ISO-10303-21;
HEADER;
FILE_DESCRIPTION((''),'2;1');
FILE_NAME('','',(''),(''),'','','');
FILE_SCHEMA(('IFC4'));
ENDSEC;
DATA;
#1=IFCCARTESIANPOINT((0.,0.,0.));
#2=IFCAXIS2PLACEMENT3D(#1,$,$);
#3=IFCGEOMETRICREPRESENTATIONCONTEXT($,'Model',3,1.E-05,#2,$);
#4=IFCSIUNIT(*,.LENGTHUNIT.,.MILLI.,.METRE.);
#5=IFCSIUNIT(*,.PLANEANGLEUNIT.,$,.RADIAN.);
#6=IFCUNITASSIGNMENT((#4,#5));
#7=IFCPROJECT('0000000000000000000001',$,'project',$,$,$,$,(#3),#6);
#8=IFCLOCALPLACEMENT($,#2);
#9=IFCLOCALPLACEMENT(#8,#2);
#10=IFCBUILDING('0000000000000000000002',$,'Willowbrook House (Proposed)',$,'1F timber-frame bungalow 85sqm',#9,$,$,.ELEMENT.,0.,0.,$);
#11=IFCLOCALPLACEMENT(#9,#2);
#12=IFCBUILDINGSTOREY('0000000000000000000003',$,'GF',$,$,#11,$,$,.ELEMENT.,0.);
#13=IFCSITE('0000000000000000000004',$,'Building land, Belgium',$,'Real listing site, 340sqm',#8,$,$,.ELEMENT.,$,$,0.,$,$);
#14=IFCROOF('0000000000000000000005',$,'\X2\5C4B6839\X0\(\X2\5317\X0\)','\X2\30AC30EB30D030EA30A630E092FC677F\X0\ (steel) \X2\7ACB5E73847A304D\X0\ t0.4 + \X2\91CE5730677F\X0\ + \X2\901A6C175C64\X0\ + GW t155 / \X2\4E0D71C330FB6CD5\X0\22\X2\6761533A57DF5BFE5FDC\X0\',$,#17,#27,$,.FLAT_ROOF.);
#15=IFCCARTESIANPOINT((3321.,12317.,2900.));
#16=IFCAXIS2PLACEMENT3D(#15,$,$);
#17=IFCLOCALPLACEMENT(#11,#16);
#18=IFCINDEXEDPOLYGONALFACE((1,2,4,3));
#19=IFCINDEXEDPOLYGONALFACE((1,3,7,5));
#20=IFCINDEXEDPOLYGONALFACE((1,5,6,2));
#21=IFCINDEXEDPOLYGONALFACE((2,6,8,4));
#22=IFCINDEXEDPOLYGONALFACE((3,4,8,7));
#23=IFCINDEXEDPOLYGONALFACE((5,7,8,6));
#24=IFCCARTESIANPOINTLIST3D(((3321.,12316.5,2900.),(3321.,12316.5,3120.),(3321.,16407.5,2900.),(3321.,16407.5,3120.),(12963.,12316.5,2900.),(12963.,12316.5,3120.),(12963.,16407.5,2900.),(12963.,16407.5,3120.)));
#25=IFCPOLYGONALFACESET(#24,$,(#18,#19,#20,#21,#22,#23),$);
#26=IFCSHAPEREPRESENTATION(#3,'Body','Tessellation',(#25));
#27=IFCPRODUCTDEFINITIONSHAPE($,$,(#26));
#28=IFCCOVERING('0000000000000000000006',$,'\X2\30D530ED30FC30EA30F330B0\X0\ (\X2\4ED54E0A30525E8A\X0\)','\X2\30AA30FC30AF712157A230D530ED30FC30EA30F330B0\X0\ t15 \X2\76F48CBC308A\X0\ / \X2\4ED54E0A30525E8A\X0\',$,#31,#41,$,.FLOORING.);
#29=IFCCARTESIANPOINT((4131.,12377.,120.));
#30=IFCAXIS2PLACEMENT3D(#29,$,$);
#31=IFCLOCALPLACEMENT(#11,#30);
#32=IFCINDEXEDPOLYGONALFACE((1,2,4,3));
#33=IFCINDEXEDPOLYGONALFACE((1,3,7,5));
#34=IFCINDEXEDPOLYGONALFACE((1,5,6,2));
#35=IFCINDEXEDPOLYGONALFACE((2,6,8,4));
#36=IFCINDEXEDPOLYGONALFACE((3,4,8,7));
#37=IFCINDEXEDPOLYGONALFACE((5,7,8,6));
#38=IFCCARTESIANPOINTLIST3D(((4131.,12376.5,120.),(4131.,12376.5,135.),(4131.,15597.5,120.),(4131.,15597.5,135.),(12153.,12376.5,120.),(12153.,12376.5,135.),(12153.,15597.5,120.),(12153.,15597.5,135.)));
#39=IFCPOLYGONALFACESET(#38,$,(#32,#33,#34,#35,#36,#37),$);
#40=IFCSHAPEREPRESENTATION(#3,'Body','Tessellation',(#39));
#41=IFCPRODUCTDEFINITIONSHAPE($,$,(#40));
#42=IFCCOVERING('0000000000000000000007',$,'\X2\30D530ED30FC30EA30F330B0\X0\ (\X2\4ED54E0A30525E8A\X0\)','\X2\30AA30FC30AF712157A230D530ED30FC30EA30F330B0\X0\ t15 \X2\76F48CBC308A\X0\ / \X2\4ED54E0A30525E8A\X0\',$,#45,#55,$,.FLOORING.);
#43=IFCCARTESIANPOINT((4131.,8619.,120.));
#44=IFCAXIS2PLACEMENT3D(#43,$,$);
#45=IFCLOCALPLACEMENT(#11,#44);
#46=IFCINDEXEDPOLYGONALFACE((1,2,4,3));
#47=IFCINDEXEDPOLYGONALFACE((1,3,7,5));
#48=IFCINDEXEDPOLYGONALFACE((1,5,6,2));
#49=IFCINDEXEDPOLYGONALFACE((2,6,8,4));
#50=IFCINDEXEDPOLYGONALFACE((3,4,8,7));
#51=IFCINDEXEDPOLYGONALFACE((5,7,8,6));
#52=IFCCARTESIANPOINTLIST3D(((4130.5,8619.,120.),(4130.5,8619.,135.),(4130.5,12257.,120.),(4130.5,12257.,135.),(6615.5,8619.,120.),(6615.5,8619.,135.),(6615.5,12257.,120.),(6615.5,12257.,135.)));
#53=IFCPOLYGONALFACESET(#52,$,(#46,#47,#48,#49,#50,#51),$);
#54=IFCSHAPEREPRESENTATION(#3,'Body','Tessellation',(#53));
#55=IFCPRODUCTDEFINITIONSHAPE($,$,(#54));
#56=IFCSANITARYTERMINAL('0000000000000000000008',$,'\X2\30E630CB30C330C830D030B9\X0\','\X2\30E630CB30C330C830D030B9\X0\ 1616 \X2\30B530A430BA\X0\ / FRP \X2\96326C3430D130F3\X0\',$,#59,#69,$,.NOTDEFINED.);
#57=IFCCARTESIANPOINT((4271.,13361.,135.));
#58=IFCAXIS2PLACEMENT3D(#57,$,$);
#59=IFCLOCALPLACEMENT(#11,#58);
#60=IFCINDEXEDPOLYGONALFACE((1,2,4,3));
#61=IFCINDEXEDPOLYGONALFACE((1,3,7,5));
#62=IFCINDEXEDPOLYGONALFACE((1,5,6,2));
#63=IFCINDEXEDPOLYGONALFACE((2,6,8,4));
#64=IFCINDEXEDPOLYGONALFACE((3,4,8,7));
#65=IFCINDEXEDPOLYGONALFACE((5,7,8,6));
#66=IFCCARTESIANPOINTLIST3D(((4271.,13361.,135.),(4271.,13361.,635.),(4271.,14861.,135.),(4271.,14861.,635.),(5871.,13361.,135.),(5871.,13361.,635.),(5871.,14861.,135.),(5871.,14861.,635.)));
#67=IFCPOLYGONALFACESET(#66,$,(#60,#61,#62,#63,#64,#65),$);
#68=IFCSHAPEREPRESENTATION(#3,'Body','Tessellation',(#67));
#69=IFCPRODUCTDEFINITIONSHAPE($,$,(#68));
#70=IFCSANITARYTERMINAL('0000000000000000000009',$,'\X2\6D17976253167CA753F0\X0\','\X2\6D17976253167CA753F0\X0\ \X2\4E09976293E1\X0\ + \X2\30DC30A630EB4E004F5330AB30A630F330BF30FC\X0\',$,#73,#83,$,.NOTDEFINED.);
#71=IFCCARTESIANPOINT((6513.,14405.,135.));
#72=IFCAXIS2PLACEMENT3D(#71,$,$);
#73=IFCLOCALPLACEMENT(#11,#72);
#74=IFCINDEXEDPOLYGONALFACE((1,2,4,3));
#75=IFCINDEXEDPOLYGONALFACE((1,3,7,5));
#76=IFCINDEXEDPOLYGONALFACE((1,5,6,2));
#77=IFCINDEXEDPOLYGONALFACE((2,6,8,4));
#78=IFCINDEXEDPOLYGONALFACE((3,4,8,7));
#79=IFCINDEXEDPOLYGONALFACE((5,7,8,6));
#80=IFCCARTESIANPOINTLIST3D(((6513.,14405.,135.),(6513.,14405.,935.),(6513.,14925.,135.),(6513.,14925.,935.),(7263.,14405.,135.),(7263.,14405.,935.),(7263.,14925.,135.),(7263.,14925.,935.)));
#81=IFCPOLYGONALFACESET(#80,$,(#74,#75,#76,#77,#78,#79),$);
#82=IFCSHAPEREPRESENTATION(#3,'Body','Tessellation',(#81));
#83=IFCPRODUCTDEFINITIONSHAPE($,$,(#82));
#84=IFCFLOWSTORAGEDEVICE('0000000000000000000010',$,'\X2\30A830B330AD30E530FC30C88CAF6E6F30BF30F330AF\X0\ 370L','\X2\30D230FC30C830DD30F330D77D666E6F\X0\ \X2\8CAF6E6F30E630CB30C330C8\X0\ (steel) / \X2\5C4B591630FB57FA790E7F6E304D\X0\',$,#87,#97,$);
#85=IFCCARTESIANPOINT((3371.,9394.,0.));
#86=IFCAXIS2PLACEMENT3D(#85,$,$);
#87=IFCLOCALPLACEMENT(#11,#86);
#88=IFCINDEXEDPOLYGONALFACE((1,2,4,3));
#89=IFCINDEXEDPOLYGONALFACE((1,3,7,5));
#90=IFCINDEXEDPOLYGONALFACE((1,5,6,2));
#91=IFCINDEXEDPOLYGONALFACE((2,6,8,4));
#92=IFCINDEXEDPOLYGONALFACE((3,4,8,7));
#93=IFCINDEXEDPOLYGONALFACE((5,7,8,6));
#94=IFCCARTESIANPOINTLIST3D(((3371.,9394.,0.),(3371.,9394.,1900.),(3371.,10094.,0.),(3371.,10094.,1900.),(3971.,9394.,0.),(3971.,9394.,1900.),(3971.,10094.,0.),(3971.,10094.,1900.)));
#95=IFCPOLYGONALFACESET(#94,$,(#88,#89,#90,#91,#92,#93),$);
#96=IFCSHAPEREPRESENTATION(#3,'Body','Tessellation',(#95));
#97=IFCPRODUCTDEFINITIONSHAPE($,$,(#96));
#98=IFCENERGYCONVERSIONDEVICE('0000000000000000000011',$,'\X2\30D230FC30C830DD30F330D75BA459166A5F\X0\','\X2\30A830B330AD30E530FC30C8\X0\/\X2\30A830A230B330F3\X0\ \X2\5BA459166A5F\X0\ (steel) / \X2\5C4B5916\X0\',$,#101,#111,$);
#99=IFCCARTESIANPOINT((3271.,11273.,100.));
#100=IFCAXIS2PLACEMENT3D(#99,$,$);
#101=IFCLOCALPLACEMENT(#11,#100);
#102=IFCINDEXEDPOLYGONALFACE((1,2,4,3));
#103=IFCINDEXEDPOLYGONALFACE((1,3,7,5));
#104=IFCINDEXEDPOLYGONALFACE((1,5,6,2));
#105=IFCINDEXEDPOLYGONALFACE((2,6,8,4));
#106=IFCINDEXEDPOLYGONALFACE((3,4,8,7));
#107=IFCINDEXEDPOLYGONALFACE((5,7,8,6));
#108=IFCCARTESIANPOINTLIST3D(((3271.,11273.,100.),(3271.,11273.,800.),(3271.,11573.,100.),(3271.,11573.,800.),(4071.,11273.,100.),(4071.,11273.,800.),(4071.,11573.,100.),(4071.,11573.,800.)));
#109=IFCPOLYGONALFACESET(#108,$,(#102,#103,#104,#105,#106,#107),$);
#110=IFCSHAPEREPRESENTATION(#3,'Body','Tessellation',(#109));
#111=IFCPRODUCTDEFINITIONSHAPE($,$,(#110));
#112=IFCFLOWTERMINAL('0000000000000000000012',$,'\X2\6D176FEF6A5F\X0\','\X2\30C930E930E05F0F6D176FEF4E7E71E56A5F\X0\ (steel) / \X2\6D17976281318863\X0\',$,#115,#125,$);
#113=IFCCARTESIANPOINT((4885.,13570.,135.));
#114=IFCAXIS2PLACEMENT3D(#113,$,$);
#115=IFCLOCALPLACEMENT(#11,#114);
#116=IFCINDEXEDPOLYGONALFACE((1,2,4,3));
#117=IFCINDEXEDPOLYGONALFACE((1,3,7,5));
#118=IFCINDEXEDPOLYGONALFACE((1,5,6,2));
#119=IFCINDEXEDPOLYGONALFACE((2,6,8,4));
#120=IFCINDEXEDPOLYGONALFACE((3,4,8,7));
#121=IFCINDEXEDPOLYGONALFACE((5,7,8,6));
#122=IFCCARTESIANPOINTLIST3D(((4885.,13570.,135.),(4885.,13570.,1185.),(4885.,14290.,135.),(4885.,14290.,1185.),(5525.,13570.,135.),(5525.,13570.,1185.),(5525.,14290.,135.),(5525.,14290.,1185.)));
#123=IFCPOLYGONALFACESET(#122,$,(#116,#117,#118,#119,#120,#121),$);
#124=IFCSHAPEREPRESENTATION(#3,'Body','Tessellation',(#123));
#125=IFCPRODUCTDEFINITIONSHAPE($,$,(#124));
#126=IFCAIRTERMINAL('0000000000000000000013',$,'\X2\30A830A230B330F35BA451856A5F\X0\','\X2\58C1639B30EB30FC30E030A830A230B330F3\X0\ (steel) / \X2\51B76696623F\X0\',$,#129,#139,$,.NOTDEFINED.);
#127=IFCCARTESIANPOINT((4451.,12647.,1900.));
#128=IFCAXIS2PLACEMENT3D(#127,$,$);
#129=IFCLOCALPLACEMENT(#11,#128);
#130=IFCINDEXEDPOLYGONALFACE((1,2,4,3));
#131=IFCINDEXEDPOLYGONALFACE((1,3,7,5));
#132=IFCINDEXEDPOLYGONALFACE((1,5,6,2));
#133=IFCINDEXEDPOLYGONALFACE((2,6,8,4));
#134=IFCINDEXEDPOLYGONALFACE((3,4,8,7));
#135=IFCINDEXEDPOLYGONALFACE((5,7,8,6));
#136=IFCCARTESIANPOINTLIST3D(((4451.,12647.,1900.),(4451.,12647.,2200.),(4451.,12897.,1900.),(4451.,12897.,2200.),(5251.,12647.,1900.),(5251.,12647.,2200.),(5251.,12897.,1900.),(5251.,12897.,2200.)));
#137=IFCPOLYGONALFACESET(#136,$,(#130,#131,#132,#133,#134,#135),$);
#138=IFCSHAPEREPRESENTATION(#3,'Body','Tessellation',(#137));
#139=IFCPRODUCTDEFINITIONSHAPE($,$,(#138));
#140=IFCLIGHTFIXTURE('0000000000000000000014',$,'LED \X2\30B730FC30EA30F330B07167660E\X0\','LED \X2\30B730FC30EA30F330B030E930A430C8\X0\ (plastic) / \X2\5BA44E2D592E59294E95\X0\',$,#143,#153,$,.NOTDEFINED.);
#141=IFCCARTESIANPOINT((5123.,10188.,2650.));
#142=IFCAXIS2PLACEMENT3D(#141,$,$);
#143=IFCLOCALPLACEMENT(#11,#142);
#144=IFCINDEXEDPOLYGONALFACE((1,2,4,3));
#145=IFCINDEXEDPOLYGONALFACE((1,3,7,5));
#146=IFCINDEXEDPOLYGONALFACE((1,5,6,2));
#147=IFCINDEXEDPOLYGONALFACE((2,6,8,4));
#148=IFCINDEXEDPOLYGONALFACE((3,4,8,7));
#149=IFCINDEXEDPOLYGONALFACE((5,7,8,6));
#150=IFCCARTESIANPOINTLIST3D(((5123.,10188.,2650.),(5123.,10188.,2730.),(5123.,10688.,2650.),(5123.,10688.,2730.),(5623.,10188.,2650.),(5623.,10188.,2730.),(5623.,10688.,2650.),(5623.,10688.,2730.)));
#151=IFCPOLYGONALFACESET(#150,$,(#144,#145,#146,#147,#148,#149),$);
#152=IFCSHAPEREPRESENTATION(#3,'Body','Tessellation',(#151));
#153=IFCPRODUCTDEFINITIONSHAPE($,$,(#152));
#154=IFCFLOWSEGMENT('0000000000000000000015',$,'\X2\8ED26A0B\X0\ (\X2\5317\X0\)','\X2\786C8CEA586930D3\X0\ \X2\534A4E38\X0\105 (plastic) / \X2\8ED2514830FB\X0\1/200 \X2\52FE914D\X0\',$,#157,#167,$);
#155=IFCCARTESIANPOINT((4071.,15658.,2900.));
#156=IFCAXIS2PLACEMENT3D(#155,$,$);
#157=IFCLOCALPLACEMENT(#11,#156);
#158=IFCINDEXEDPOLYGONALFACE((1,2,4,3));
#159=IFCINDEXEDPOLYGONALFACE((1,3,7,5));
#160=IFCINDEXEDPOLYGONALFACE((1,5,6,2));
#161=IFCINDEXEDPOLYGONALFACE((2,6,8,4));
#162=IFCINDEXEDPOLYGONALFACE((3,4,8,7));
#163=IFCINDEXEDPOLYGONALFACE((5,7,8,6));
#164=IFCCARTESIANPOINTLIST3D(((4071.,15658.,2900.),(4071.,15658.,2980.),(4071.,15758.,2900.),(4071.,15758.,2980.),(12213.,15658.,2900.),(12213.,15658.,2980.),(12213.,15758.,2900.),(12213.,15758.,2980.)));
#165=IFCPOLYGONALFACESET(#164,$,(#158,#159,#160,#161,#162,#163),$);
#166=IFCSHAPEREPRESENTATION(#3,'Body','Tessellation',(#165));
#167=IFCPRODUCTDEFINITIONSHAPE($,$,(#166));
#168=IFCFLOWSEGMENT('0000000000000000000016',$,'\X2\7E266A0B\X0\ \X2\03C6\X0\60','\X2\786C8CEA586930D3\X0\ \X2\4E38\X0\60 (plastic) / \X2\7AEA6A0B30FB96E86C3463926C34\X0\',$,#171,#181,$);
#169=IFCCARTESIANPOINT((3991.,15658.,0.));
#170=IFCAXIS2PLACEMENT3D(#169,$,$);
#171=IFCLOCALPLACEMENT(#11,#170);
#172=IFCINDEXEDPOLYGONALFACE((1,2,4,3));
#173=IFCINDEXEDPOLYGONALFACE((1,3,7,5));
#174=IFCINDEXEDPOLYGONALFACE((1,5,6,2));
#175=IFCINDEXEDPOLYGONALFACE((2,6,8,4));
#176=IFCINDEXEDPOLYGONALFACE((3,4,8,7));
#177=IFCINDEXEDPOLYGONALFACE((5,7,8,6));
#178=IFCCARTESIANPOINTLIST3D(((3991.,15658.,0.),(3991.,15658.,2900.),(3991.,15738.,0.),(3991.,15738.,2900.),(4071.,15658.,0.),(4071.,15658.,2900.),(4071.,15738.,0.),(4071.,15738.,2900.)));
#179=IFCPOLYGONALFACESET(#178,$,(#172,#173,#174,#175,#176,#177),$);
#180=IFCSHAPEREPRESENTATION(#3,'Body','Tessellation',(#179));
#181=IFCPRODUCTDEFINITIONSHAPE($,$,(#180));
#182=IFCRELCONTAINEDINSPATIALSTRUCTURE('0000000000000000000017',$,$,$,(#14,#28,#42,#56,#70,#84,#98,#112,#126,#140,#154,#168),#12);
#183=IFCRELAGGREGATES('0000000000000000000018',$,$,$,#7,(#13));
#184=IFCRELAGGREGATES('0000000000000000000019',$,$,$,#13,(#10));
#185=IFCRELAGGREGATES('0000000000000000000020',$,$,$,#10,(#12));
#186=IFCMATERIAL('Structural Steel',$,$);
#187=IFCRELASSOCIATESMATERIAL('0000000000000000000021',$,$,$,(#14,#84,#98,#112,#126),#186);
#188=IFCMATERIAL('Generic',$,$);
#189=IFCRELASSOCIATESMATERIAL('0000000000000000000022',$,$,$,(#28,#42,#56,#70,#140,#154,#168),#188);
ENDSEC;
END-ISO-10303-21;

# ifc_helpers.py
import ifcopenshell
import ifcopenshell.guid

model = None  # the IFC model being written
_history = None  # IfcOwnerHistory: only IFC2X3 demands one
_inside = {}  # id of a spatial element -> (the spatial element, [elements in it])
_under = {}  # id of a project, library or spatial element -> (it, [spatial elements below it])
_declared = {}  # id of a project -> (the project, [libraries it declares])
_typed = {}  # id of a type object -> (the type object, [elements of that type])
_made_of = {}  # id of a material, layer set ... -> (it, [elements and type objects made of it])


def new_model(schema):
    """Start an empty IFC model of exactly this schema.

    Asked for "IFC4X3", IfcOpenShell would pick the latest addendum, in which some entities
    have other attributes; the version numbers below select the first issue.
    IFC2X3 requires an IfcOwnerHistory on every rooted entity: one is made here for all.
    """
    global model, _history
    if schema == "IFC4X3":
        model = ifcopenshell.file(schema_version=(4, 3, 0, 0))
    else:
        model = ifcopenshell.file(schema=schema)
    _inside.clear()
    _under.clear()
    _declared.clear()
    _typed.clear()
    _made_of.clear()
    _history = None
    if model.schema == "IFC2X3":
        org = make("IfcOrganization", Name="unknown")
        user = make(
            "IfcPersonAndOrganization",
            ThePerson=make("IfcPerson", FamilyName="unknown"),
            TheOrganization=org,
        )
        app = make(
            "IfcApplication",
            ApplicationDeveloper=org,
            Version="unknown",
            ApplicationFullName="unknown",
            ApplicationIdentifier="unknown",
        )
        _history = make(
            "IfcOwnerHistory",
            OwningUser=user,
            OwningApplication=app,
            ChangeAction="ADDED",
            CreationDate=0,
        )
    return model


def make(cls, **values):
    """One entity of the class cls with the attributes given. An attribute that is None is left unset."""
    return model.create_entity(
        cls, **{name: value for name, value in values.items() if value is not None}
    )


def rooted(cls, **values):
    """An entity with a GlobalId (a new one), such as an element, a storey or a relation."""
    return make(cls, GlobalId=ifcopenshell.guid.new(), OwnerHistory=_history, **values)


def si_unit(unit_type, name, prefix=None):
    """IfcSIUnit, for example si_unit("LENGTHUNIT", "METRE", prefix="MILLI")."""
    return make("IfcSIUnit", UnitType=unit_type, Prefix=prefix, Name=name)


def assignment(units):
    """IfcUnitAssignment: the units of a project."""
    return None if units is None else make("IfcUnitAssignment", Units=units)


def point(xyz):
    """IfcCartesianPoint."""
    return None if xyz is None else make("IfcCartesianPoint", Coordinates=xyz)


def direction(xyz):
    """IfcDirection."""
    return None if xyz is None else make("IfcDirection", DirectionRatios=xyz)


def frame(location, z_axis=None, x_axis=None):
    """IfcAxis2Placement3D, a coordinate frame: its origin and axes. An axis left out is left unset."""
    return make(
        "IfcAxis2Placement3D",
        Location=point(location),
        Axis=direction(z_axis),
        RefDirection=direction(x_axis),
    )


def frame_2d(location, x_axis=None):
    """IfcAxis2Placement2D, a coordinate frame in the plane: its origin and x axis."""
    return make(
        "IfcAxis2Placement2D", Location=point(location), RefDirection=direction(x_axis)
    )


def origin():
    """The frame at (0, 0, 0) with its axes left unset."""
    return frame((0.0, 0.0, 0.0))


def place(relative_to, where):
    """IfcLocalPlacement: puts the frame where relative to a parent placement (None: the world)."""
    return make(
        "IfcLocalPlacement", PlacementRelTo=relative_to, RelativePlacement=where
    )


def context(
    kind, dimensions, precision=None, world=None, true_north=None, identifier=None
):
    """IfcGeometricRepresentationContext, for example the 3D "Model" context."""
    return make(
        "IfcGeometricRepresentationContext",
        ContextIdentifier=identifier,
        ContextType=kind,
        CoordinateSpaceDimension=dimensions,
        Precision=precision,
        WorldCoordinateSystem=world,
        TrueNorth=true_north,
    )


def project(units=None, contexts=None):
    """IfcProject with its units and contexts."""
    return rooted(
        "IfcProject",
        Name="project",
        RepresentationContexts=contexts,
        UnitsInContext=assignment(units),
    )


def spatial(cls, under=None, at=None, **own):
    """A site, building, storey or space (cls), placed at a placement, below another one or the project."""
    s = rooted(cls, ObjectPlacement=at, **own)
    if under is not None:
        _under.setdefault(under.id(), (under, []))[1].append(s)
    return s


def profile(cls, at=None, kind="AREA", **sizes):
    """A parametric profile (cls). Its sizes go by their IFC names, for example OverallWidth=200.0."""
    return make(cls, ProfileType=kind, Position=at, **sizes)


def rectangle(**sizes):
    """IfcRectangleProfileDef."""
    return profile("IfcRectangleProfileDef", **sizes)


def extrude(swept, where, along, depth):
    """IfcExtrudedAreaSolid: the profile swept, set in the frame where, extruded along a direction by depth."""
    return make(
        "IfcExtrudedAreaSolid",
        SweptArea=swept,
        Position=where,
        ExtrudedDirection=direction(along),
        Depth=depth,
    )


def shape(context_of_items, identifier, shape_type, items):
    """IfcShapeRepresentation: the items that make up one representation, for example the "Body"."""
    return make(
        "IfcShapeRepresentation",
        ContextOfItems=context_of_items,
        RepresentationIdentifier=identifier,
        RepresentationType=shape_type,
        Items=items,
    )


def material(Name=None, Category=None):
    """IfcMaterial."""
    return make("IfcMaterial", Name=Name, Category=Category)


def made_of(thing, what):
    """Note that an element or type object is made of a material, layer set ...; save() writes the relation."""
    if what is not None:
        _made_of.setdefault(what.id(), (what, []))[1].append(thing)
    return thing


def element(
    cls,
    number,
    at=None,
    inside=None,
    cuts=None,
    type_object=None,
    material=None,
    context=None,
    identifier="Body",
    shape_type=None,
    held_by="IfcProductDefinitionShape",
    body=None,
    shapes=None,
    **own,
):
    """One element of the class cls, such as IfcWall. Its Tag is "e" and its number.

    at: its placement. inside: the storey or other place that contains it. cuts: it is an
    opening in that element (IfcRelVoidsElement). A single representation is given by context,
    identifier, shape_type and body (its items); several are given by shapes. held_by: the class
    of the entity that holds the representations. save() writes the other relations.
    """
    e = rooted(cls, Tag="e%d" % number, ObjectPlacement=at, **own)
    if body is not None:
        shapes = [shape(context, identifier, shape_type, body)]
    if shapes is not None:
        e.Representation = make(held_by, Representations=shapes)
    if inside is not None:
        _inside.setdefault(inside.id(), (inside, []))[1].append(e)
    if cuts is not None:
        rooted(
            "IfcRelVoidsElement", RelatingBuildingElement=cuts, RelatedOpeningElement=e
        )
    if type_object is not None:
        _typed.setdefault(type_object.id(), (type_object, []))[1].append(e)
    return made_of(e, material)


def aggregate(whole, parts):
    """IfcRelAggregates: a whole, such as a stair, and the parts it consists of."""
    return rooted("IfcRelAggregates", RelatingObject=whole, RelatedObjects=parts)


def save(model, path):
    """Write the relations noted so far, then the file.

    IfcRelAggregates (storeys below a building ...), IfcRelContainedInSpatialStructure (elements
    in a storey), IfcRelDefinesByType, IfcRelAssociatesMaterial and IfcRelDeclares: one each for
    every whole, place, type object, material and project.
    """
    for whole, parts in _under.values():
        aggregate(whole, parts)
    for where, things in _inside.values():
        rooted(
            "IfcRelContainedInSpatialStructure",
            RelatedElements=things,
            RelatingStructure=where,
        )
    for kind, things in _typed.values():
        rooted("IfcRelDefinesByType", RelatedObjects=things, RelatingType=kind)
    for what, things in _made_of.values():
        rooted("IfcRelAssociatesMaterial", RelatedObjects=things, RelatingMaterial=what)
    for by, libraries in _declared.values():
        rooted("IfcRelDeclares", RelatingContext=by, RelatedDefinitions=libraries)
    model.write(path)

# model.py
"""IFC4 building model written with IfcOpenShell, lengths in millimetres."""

from ifc_helpers import new_model, si_unit, frame, frame_2d, origin, place, context, project, spatial, rectangle, extrude, material, element, save


model = new_model("IFC4")

# Units and contexts
model_context = context("Model", 3, precision=1e-05, world=origin())
ifc_project = project(units=[si_unit("LENGTHUNIT", "METRE", prefix="MILLI"), si_unit("PLANEANGLEUNIT", "RADIAN")], contexts=[model_context])

# Site, building, storey
site_placement = place(None, origin())
site = spatial("IfcSite", under=ifc_project, at=site_placement, Name="Building land, Belgium", ObjectType="Real listing site, 340sqm", CompositionType="ELEMENT", RefElevation=0.0)
building_placement = place(site_placement, origin())
building = spatial("IfcBuilding", under=site, at=building_placement, Name="Willowbrook House (Proposed)", ObjectType="1F timber-frame bungalow 85sqm", CompositionType="ELEMENT", ElevationOfRefHeight=0.0, ElevationOfTerrain=0.0)
storey_placement = place(building_placement, origin())
storey = spatial("IfcBuildingStorey", under=building, at=storey_placement, Name="GF", CompositionType="ELEMENT", Elevation=0.0)

# Roof
ifc_material_1 = material(Name="Structural Steel")
roof_placement = place(storey_placement, frame((3321.0, 12317.0, 2900.0)))
element("IfcRoof", 1, at=roof_placement, inside=storey, material=ifc_material_1, Name="屋根(北)", Description="ガルバリウム鋼板 (steel) 立平葺き t0.4 + 野地板 + 通気層 + GW t155 / 不燃・法22条区域対応", PredefinedType="FLAT_ROOF", context=model_context, shape_type="SweptSolid", body=[
    extrude(rectangle(XDim=9642.0, YDim=4091.0, at=frame_2d((4821.0, 2045.0))), frame((3321.0, 12317.0, 2900.0)), (0.0, 0.0, 1.0), 220.0),
])

# Coverings
ifc_material_2 = material(Name="Generic")
covering_1_placement = place(storey_placement, frame((4131.0, 12377.0, 120.0)))
element("IfcCovering", 2, at=covering_1_placement, inside=storey, material=ifc_material_2, Name="フローリング (仕上げ床)", Description="オーク無垢フローリング t15 直貼り / 仕上げ床", PredefinedType="FLOORING", context=model_context, shape_type="SweptSolid", body=[
    extrude(rectangle(XDim=8022.0, YDim=3221.0, at=frame_2d((4011.0, 1610.0))), frame((4131.0, 12377.0, 120.0)), (0.0, 0.0, 1.0), 15.0),
])
covering_2_placement = place(storey_placement, frame((4131.0, 8619.0, 120.0)))
element("IfcCovering", 3, at=covering_2_placement, inside=storey, material=ifc_material_2, Name="フローリング (仕上げ床)", Description="オーク無垢フローリング t15 直貼り / 仕上げ床", PredefinedType="FLOORING", context=model_context, shape_type="SweptSolid", body=[
    extrude(rectangle(XDim=2485.0, YDim=3638.0, at=frame_2d((1242.0, 1819.0))), frame((4131.0, 8619.0, 120.0)), (0.0, 0.0, 1.0), 15.0),
])

# Sanitary terminals
sanitary_terminal_1_placement = place(storey_placement, frame((4271.0, 13361.0, 135.0)))
element("IfcSanitaryTerminal", 4, at=sanitary_terminal_1_placement, inside=storey, material=ifc_material_2, Name="ユニットバス", Description="ユニットバス 1616 サイズ / FRP 防水パン", PredefinedType="NOTDEFINED", context=model_context, shape_type="SweptSolid", body=[
    extrude(rectangle(XDim=1600.0, YDim=1500.0, at=frame_2d((800.0, 750.0))), frame((4271.0, 13361.0, 135.0)), (0.0, 0.0, 1.0), 500.0),
])
sanitary_terminal_2_placement = place(storey_placement, frame((6513.0, 14405.0, 135.0)))
element("IfcSanitaryTerminal", 5, at=sanitary_terminal_2_placement, inside=storey, material=ifc_material_2, Name="洗面化粧台", Description="洗面化粧台 三面鏡 + ボウル一体カウンター", PredefinedType="NOTDEFINED", context=model_context, shape_type="SweptSolid", body=[
    extrude(rectangle(XDim=750.0, YDim=520.0, at=frame_2d((375.0, 260.0))), frame((6513.0, 14405.0, 135.0)), (0.0, 0.0, 1.0), 800.0),
])

# Flow storage device
flow_storage_device_placement = place(storey_placement, frame((3371.0, 9394.0, 0.0)))
element("IfcFlowStorageDevice", 6, at=flow_storage_device_placement, inside=storey, material=ifc_material_1, Name="エコキュート貯湯タンク 370L", Description="ヒートポンプ給湯 貯湯ユニット (steel) / 屋外・基礎置き", context=model_context, shape_type="SweptSolid", body=[
    extrude(rectangle(XDim=600.0, YDim=700.0, at=frame_2d((300.0, 350.0))), frame((3371.0, 9394.0, 0.0)), (0.0, 0.0, 1.0), 1900.0),
])

# Energy conversion device
energy_conversion_device_placement = place(storey_placement, frame((3271.0, 11273.0, 100.0)))
element("IfcEnergyConversionDevice", 7, at=energy_conversion_device_placement, inside=storey, material=ifc_material_1, Name="ヒートポンプ室外機", Description="エコキュート/エアコン 室外機 (steel) / 屋外", context=model_context, shape_type="SweptSolid", body=[
    extrude(rectangle(XDim=800.0, YDim=300.0, at=frame_2d((400.0, 150.0))), frame((3271.0, 11273.0, 100.0)), (0.0, 0.0, 1.0), 700.0),
])

# Flow terminal
flow_terminal_placement = place(storey_placement, frame((4885.0, 13570.0, 135.0)))
element("IfcFlowTerminal", 8, at=flow_terminal_placement, inside=storey, material=ifc_material_1, Name="洗濯機", Description="ドラム式洗濯乾燥機 (steel) / 洗面脱衣", context=model_context, shape_type="SweptSolid", body=[
    extrude(rectangle(XDim=640.0, YDim=720.0, at=frame_2d((320.0, 360.0))), frame((4885.0, 13570.0, 135.0)), (0.0, 0.0, 1.0), 1050.0),
])

# Air terminal
air_terminal_placement = place(storey_placement, frame((4451.0, 12647.0, 1900.0)))
element("IfcAirTerminal", 9, at=air_terminal_placement, inside=storey, material=ifc_material_1, Name="エアコン室内機", Description="壁掛ルームエアコン (steel) / 冷暖房", PredefinedType="NOTDEFINED", context=model_context, shape_type="SweptSolid", body=[
    extrude(rectangle(XDim=800.0, YDim=250.0, at=frame_2d((400.0, 125.0))), frame((4451.0, 12647.0, 1900.0)), (0.0, 0.0, 1.0), 300.0),
])

# Light fixture
light_fixture_placement = place(storey_placement, frame((5123.0, 10188.0, 2650.0)))
element("IfcLightFixture", 10, at=light_fixture_placement, inside=storey, material=ifc_material_2, Name="LED シーリング照明", Description="LED シーリングライト (plastic) / 室中央天井", PredefinedType="NOTDEFINED", context=model_context, shape_type="SweptSolid", body=[
    extrude(rectangle(XDim=500.0, YDim=500.0, at=frame_2d((250.0, 250.0))), frame((5123.0, 10188.0, 2650.0)), (0.0, 0.0, 1.0), 80.0),
])

# Flow segments
flow_segment_1_placement = place(storey_placement, frame((4071.0, 15658.0, 2900.0)))
element("IfcFlowSegment", 11, at=flow_segment_1_placement, inside=storey, material=ifc_material_2, Name="軒樋 (北)", Description="硬質塩ビ 半丸105 (plastic) / 軒先・1/200 勾配", context=model_context, shape_type="SweptSolid", body=[
    extrude(rectangle(XDim=8142.0, YDim=100.0, at=frame_2d((4071.0, 50.0))), frame((4071.0, 15658.0, 2900.0)), (0.0, 0.0, 1.0), 80.0),
])
flow_segment_2_placement = place(storey_placement, frame((3991.0, 15658.0, 0.0)))
element("IfcFlowSegment", 12, at=flow_segment_2_placement, inside=storey, material=ifc_material_2, Name="縦樋 φ60", Description="硬質塩ビ 丸60 (plastic) / 竪樋・雨水排水", context=model_context, shape_type="SweptSolid", body=[
    extrude(rectangle(XDim=80.0, YDim=80.0, at=frame_2d((40.0, 40.0))), frame((3991.0, 15658.0, 0.0)), (0.0, 0.0, 1.0), 2900.0),
])

save(model, "model.ifc")
